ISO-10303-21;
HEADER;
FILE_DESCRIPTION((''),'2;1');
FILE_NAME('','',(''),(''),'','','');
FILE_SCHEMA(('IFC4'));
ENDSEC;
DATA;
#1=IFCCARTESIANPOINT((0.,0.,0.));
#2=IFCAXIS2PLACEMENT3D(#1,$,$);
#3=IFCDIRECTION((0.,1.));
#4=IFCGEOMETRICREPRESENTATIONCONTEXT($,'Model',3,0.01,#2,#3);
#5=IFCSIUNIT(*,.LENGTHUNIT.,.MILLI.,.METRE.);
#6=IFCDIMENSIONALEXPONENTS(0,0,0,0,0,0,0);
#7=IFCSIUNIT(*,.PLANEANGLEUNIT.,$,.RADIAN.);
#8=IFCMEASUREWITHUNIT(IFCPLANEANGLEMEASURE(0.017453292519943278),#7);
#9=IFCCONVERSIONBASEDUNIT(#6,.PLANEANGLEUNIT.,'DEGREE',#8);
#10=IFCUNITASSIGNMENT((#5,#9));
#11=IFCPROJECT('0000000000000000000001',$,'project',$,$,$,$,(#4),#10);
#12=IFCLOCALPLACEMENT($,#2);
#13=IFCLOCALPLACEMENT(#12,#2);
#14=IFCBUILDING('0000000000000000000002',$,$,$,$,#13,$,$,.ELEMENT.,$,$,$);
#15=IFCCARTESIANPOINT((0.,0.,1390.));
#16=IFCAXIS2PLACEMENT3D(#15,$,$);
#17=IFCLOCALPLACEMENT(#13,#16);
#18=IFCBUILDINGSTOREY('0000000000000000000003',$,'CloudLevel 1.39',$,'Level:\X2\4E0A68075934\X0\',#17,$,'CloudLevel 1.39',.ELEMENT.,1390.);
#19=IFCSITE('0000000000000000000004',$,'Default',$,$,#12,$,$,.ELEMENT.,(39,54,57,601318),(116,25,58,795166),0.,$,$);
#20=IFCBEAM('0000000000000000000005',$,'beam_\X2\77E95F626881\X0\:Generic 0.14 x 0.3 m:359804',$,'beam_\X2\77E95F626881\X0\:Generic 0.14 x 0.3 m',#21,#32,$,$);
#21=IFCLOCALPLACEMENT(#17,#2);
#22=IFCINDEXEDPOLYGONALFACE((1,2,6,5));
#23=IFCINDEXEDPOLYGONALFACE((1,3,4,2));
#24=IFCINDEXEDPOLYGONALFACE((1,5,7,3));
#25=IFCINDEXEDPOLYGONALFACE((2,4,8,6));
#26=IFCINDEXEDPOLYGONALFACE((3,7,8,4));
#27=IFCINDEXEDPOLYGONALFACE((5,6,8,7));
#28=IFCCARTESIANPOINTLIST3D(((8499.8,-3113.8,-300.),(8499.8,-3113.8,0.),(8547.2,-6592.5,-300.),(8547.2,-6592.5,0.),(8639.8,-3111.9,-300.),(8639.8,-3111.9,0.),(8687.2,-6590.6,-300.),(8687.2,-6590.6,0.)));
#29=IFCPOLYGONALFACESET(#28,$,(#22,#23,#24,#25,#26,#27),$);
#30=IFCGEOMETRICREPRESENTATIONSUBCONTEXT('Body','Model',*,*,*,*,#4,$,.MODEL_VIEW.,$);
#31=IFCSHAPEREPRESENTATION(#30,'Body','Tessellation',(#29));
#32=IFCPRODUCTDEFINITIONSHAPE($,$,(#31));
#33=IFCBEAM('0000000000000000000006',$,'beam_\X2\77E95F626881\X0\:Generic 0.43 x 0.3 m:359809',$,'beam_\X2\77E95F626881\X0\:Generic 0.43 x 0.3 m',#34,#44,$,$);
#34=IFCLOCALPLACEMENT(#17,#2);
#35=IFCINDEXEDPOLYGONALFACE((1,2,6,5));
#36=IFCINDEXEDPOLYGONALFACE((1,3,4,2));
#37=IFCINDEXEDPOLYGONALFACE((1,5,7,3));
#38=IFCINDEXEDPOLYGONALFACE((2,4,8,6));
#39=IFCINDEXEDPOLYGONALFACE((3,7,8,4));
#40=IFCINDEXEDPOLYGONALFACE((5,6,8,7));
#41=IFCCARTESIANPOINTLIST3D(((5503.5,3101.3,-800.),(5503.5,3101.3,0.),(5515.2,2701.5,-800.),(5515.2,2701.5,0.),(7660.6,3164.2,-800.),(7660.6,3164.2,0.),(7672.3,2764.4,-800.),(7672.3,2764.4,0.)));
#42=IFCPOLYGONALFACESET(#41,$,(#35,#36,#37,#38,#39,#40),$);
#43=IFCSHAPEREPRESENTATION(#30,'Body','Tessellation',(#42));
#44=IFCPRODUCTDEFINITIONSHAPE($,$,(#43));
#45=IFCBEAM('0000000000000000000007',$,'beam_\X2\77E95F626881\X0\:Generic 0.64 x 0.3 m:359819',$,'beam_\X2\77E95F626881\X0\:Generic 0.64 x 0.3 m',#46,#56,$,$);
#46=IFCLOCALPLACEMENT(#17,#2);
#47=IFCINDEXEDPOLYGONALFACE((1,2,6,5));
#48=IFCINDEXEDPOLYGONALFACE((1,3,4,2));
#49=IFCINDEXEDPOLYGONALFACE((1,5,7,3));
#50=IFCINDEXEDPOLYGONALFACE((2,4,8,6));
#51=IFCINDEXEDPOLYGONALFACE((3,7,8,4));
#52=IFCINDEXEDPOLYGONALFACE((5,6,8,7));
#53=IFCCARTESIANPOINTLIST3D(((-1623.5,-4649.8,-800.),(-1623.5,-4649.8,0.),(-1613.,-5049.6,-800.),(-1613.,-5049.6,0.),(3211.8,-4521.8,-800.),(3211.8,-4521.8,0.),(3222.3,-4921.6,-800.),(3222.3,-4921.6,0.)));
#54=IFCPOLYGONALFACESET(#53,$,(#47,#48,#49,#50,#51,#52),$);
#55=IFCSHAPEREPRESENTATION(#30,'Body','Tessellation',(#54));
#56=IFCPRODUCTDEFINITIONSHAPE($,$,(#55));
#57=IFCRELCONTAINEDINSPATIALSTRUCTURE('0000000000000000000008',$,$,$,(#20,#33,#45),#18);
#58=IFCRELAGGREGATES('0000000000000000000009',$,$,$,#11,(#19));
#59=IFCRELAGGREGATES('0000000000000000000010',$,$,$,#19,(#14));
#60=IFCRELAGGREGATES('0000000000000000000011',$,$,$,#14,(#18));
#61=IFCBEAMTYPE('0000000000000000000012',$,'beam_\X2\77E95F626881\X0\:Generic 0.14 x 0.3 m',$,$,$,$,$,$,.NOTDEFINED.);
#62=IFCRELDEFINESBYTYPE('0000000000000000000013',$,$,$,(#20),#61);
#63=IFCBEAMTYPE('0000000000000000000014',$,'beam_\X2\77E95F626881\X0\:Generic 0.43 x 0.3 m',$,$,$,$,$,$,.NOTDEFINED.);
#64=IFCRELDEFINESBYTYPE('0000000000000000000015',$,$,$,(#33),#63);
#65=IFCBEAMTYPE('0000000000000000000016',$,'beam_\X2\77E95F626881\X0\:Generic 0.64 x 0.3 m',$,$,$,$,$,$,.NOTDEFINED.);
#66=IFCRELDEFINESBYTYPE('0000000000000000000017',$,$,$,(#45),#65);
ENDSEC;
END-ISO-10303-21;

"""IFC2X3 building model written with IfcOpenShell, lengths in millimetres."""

from ifc_helpers import new_model, entity, si_unit, converted_unit, direction, frame, frame_2d, origin, origin_2d_with_axis, place, context, subcontext, project, spatial, rectangle, extrude, type_object, element, save


model = new_model("IFC2X3")

# Units and contexts
model_context = context("Model", 3, precision=0.01, world=origin(), true_north=direction((0.0, 1.0)))
body_context = subcontext(model_context, "Body", "Model", "MODEL_VIEW")
ifc_project = project(units=[si_unit("LENGTHUNIT", "METRE", prefix="MILLI"), converted_unit("PLANEANGLEUNIT", "DEGREE", entity("IfcPlaneAngleMeasure", 0.017453292519943278), si_unit("PLANEANGLEUNIT", "RADIAN"), dimensions=[0, 0, 0, 0, 0, 0, 0])], contexts=[model_context])

# Site, building, storey
site_placement = place(None, origin())
site = spatial("IfcSite", under=ifc_project, at=site_placement, Name="Default", CompositionType="ELEMENT", RefLatitude=(39, 54, 57, 601318), RefLongitude=(116, 25, 58, 795166), RefElevation=0.0)
building_placement = place(site_placement, origin())
building = spatial("IfcBuilding", under=site, at=building_placement, CompositionType="ELEMENT")
storey_placement = place(building_placement, frame((0.0, 0.0, 1390.0)))
storey = spatial("IfcBuildingStorey", under=building, at=storey_placement, Name="CloudLevel 1.39", ObjectType="Level:上标头", LongName="CloudLevel 1.39", CompositionType="ELEMENT", Elevation=1390.0)

# Beams
beam_type_1 = type_object("IfcBeamType", Name="beam_矩形梁:Generic 0.14 x 0.3 m", PredefinedType="NOTDEFINED")
beam_1_placement = place(storey_placement, frame((8569.8, -3112.7, 0.0), z_axis=(0.0, 0.0, 1.0), x_axis=(0.01363, -0.999907, 0.0)))
element("IfcBeam", 1, at=beam_1_placement, inside=storey, type_object=beam_type_1, Name="beam_矩形梁:Generic 0.14 x 0.3 m:359804", ObjectType="beam_矩形梁:Generic 0.14 x 0.3 m", context=body_context, shape_type="SweptSolid", body=[
    extrude(rectangle(XDim=300.0, YDim=140.0, at=frame_2d((0.0, 0.0), x_axis=(1.0, 0.0))), frame((0.1, 0.0, -150.0), z_axis=(1.0, 0.0, 0.0), x_axis=(0.0, 0.0, -1.0)), (0.0, 0.0, 1.0), 3479.0),
])
beam_type_2 = type_object("IfcBeamType", Name="beam_矩形梁:Generic 0.43 x 0.3 m", PredefinedType="NOTDEFINED")
beam_2_placement = place(storey_placement, frame((7666.5, 2964.3, 0.0), z_axis=(0.0, 0.0, 1.0), x_axis=(-0.999575, -0.029152, 0.0)))
element("IfcBeam", 2, at=beam_2_placement, inside=storey, type_object=beam_type_2, Name="beam_矩形梁:Generic 0.43 x 0.3 m:359809", ObjectType="beam_矩形梁:Generic 0.43 x 0.3 m", context=body_context, shape_type="SweptSolid", body=[
    extrude(rectangle(XDim=800.0, YDim=400.0, at=origin_2d_with_axis()), frame((0.1, 0.0, -400.0), z_axis=(1.0, 0.0, 0.0), x_axis=(0.0, 0.0, -1.0)), (0.0, 0.0, 1.0), 2158.0),
])
beam_type_3 = type_object("IfcBeamType", Name="beam_矩形梁:Generic 0.64 x 0.3 m", PredefinedType="NOTDEFINED")
beam_3_placement = place(storey_placement, frame((3217.4, -4721.7, 0.0), z_axis=(0.0, 0.0, 1.0), x_axis=(-0.99965, -0.026459, 0.0)))
element("IfcBeam", 3, at=beam_3_placement, inside=storey, type_object=beam_type_3, Name="beam_矩形梁:Generic 0.64 x 0.3 m:359819", ObjectType="beam_矩形梁:Generic 0.64 x 0.3 m", context=body_context, shape_type="SweptSolid", body=[
    extrude(rectangle(XDim=800.0, YDim=400.0, at=frame_2d((0.0, 0.0), x_axis=(1.0, 0.0))), frame((0.4, 0.0, -400.0), z_axis=(1.0, 0.0, 0.0), x_axis=(0.0, 0.0, -1.0)), (0.0, 0.0, 1.0), 4837.0),
])

save(model, "model.ifc")
